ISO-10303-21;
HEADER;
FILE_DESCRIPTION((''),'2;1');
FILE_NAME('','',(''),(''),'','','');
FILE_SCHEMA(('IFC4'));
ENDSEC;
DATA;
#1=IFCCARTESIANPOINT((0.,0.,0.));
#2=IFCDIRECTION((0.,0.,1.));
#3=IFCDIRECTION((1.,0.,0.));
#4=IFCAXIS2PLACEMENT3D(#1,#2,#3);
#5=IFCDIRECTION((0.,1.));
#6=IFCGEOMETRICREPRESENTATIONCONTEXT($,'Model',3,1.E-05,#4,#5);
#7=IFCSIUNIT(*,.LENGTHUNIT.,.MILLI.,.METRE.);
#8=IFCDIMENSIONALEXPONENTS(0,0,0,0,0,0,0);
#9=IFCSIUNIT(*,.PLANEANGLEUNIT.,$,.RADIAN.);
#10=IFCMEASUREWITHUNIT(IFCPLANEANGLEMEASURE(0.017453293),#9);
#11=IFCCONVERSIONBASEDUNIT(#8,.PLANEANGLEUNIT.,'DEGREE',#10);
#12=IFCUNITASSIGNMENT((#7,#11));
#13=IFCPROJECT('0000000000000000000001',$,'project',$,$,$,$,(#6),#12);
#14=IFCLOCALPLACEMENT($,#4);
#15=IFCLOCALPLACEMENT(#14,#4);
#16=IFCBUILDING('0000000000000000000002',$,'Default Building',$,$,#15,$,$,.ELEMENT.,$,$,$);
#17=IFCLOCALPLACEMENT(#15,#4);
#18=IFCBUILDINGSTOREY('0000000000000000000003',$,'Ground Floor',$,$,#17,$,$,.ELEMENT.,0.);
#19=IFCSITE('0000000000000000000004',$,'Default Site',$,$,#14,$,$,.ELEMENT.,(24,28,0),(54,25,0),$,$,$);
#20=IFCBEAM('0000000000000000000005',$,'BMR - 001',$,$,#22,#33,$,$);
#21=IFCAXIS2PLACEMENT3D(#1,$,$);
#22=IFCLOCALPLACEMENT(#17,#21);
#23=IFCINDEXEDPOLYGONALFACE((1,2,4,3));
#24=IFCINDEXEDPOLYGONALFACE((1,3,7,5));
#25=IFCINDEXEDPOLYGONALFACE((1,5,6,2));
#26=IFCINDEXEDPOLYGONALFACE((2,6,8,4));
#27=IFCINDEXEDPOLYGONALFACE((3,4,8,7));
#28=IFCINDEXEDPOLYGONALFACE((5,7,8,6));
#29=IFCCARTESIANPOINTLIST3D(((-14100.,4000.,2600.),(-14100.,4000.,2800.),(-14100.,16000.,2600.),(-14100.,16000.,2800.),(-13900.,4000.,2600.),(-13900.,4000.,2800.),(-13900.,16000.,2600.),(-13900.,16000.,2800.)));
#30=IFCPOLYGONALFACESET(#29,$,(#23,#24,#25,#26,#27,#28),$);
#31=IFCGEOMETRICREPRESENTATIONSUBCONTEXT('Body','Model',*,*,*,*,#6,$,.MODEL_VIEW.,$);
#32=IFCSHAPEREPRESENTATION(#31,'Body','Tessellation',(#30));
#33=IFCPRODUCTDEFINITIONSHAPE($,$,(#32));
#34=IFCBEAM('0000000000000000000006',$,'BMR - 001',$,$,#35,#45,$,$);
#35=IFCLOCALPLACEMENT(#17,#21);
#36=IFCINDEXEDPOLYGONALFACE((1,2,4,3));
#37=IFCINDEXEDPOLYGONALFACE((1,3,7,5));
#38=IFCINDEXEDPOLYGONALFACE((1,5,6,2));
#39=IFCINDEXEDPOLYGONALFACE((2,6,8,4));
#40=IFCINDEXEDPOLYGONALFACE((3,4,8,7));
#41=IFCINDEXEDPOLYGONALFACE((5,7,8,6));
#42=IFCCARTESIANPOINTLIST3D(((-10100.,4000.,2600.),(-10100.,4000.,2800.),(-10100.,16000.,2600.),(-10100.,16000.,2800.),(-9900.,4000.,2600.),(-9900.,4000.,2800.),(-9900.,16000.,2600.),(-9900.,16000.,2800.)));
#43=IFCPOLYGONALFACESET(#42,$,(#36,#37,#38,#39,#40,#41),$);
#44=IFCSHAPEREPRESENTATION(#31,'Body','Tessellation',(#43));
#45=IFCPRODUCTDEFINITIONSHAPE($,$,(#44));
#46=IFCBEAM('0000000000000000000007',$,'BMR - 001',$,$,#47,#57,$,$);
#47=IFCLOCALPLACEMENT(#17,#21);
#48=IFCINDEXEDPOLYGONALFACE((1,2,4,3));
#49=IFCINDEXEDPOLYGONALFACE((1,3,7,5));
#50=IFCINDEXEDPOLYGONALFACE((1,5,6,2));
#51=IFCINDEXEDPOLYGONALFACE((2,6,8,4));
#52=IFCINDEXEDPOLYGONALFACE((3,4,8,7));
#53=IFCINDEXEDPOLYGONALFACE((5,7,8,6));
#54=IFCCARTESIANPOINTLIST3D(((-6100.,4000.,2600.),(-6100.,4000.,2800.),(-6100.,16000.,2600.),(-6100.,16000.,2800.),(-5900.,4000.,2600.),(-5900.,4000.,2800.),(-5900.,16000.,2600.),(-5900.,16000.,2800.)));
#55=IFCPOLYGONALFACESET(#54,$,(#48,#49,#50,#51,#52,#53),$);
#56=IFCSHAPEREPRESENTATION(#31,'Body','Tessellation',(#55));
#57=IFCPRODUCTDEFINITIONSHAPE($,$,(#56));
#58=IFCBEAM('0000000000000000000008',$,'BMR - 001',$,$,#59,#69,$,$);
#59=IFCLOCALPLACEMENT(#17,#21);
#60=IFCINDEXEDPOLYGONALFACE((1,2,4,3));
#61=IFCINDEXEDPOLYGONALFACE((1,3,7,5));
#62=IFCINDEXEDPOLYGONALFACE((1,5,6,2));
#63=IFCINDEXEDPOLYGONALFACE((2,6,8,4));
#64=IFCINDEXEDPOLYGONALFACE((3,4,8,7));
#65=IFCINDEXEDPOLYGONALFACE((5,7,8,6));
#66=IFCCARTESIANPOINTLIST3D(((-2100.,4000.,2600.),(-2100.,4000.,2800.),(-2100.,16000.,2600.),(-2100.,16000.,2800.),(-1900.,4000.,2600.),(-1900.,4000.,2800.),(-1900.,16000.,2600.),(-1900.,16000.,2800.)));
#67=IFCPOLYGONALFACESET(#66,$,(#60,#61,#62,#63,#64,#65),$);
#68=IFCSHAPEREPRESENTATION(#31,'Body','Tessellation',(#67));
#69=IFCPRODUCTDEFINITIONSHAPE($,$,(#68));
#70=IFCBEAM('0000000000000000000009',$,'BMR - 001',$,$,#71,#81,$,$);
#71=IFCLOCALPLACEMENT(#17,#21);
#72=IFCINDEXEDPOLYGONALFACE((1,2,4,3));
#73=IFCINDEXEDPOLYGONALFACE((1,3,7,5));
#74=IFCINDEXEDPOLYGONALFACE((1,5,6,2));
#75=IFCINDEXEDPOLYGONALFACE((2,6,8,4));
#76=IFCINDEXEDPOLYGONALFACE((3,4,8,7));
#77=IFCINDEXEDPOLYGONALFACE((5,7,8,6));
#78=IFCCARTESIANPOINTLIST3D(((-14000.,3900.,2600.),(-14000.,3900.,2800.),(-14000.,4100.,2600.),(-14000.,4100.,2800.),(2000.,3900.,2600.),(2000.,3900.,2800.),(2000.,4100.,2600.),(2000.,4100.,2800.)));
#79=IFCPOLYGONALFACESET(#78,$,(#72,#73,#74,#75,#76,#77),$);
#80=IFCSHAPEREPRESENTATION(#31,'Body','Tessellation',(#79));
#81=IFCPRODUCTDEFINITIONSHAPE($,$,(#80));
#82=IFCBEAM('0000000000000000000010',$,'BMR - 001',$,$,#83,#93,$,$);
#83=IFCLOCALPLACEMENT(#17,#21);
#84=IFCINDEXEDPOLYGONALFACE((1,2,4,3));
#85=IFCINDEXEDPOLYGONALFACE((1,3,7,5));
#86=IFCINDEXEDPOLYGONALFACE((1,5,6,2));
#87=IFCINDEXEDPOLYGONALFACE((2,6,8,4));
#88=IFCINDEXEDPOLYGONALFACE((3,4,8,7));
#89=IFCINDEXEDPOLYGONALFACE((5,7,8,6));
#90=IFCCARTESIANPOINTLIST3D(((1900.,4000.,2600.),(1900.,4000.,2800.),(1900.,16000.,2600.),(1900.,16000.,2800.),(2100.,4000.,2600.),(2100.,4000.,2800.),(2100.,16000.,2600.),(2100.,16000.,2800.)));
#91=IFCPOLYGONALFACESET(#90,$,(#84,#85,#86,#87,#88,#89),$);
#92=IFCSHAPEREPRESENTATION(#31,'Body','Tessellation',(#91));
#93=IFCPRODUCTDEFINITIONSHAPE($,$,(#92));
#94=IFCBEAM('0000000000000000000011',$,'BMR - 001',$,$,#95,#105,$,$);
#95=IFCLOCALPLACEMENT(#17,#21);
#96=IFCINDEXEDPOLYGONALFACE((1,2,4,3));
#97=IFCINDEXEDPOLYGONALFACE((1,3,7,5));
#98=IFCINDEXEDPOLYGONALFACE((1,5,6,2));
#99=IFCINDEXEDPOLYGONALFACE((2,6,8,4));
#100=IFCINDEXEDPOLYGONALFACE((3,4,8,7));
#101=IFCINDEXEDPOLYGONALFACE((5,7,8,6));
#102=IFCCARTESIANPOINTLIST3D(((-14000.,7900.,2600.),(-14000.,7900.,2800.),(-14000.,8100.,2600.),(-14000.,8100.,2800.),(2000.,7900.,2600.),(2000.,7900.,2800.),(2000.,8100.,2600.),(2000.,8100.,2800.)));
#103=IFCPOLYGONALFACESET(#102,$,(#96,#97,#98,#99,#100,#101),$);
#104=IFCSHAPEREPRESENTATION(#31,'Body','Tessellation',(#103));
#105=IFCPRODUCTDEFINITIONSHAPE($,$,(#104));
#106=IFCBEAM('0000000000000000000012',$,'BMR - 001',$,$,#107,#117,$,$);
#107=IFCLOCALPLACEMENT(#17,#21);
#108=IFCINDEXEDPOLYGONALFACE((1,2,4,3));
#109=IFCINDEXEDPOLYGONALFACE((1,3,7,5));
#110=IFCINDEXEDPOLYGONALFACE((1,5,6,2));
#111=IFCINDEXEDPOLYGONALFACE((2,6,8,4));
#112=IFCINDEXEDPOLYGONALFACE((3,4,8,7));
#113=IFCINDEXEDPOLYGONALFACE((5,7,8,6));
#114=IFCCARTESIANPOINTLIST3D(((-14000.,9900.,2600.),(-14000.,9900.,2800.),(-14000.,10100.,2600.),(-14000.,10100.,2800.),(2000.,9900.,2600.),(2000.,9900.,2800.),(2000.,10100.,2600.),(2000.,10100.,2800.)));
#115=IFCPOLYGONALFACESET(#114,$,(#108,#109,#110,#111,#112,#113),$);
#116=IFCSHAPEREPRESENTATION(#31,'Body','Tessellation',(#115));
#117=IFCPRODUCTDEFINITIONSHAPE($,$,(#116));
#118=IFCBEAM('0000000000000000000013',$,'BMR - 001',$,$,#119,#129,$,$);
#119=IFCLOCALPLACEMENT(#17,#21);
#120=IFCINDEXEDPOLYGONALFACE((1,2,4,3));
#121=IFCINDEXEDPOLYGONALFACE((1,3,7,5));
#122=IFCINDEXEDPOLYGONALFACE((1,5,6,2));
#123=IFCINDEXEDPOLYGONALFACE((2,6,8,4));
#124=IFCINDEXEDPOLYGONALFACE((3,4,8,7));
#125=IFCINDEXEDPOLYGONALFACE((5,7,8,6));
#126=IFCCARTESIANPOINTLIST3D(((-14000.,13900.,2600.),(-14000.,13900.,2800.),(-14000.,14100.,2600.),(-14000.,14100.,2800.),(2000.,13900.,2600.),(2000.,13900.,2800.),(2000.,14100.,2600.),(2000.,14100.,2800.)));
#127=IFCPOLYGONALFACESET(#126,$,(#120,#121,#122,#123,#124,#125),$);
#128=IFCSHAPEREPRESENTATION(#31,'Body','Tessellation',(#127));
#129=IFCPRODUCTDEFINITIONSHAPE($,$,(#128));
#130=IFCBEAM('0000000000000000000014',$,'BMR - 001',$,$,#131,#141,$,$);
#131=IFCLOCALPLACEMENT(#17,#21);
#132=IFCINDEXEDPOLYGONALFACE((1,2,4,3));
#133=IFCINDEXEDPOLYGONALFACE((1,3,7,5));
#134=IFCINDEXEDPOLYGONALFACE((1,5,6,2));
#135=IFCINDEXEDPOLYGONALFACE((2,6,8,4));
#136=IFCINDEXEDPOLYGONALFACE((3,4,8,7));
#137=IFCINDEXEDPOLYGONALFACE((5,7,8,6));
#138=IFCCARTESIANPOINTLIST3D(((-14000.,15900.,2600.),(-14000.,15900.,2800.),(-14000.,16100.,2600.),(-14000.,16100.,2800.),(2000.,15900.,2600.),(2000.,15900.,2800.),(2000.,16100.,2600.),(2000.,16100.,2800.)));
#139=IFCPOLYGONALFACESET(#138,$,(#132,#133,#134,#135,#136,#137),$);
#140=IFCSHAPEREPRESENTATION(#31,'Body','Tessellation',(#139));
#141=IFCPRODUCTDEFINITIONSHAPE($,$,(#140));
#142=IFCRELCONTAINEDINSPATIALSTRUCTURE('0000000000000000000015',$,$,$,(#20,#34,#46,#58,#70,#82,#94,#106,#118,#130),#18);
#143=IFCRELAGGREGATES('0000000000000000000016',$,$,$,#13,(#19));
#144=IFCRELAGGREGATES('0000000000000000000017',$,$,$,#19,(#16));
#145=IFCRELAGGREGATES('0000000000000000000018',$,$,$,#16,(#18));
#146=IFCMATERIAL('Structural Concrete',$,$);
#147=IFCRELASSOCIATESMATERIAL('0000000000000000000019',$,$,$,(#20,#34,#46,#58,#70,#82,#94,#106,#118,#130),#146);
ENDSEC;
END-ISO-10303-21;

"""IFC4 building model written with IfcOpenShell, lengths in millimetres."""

from ifc_helpers import new_model, entity, si_unit, converted_unit, direction, frame, frame_2d, origin_with_axes, place, context, subcontext, project, spatial, rectangle, extrude, material, element, save


model = new_model("IFC4")

# Units and contexts
model_context = context("Model", 3, precision=1e-05, world=origin_with_axes(), true_north=direction((0.0, 1.0)))
body_context = subcontext(model_context, "Body", "Model", "MODEL_VIEW")
ifc_project = project(units=[si_unit("LENGTHUNIT", "METRE", prefix="MILLI"), converted_unit("PLANEANGLEUNIT", "DEGREE", entity("IfcPlaneAngleMeasure", 0.017453293), si_unit("PLANEANGLEUNIT", "RADIAN"), dimensions=[0, 0, 0, 0, 0, 0, 0])], contexts=[model_context])

# Site, building, storey
site_placement = place(None, origin_with_axes())
site = spatial("IfcSite", under=ifc_project, at=site_placement, Name="Default Site", CompositionType="ELEMENT", RefLatitude=(24, 28, 0), RefLongitude=(54, 25, 0))
building_placement = place(site_placement, origin_with_axes())
building = spatial("IfcBuilding", under=site, at=building_placement, Name="Default Building", CompositionType="ELEMENT")
storey_placement = place(building_placement, origin_with_axes())
storey = spatial("IfcBuildingStorey", under=building, at=storey_placement, Name="Ground Floor", CompositionType="ELEMENT", Elevation=0.0)

# Beams
ifc_material = material(Name="Structural Concrete")
for number, where, z_axis, x_axis, name in (
    (1, (-14000.0, 4000.0, 2800.0), (0.0, 0.0, 1.0), (1.0, 0.0, 0.0), "BMR - 001"),
    (2, (-10000.0, 4000.0, 2800.0), (0.0, 0.0, 1.0), (1.0, 0.0, 0.0), "BMR - 001"),
    (3, (-6000.0, 4000.0, 2800.0), (0.0, 0.0, 1.0), (1.0, 0.0, 0.0), "BMR - 001"),
    (4, (-2000.0, 4000.0, 2800.0), (0.0, 0.0, 1.0), (1.0, 0.0, 0.0), "BMR - 001"),
):
    element("IfcBeam", number, at=place(storey_placement, frame(where, z_axis=z_axis, x_axis=x_axis)), inside=storey, material=ifc_material, Name=name, context=body_context, shape_type="SweptSolid", body=[
        extrude(rectangle(XDim=200.0, YDim=200.0, at=frame_2d((-100.0, 0.0), x_axis=(1.0, 0.0))), frame((0.0, 0.0, 0.0), z_axis=(0.0, 1.0, 0.0), x_axis=(0.0, 0.0, 1.0)), (0.0, 0.0, 1.0), 12000.0),
    ])
beam_1_placement = place(storey_placement, frame((-14000.0, 4000.0, 2800.0), z_axis=(0.0, 0.0, 1.0), x_axis=(0.0, -1.0, 0.0)))
element("IfcBeam", 5, at=beam_1_placement, inside=storey, material=ifc_material, Name="BMR - 001", context=body_context, shape_type="SweptSolid", body=[
    extrude(rectangle(XDim=200.0, YDim=200.0, at=frame_2d((-100.0, 0.0), x_axis=(1.0, 0.0))), frame((0.0, 0.0, 0.0), z_axis=(0.0, 1.0, 0.0), x_axis=(0.0, 0.0, 1.0)), (0.0, 0.0, 1.0), 16000.0),
])
beam_2_placement = place(storey_placement, frame((2000.0, 4000.0, 2800.0), z_axis=(0.0, 0.0, 1.0), x_axis=(1.0, 0.0, 0.0)))
element("IfcBeam", 6, at=beam_2_placement, inside=storey, material=ifc_material, Name="BMR - 001", context=body_context, shape_type="SweptSolid", body=[
    extrude(rectangle(XDim=200.0, YDim=200.0, at=frame_2d((-100.0, 0.0), x_axis=(1.0, 0.0))), frame((0.0, 0.0, 0.0), z_axis=(0.0, 1.0, 0.0), x_axis=(0.0, 0.0, 1.0)), (0.0, 0.0, 1.0), 12000.0),
])
for number, where, z_axis, x_axis, name in (
    (7, (-14000.0, 8000.0, 2800.0), (0.0, 0.0, 1.0), (0.0, -1.0, 0.0), "BMR - 001"),
    (8, (-14000.0, 10000.0, 2800.0), (0.0, 0.0, 1.0), (0.0, -1.0, 0.0), "BMR - 001"),
    (9, (-14000.0, 14000.0, 2800.0), (0.0, 0.0, 1.0), (0.0, -1.0, 0.0), "BMR - 001"),
    (10, (-14000.0, 16000.0, 2800.0), (0.0, 0.0, 1.0), (0.0, -1.0, 0.0), "BMR - 001"),
):
    element("IfcBeam", number, at=place(storey_placement, frame(where, z_axis=z_axis, x_axis=x_axis)), inside=storey, material=ifc_material, Name=name, context=body_context, shape_type="SweptSolid", body=[
        extrude(rectangle(XDim=200.0, YDim=200.0, at=frame_2d((-100.0, 0.0), x_axis=(1.0, 0.0))), frame((0.0, 0.0, 0.0), z_axis=(0.0, 1.0, 0.0), x_axis=(0.0, 0.0, 1.0)), (0.0, 0.0, 1.0), 16000.0),
    ])

save(model, "model.ifc")
